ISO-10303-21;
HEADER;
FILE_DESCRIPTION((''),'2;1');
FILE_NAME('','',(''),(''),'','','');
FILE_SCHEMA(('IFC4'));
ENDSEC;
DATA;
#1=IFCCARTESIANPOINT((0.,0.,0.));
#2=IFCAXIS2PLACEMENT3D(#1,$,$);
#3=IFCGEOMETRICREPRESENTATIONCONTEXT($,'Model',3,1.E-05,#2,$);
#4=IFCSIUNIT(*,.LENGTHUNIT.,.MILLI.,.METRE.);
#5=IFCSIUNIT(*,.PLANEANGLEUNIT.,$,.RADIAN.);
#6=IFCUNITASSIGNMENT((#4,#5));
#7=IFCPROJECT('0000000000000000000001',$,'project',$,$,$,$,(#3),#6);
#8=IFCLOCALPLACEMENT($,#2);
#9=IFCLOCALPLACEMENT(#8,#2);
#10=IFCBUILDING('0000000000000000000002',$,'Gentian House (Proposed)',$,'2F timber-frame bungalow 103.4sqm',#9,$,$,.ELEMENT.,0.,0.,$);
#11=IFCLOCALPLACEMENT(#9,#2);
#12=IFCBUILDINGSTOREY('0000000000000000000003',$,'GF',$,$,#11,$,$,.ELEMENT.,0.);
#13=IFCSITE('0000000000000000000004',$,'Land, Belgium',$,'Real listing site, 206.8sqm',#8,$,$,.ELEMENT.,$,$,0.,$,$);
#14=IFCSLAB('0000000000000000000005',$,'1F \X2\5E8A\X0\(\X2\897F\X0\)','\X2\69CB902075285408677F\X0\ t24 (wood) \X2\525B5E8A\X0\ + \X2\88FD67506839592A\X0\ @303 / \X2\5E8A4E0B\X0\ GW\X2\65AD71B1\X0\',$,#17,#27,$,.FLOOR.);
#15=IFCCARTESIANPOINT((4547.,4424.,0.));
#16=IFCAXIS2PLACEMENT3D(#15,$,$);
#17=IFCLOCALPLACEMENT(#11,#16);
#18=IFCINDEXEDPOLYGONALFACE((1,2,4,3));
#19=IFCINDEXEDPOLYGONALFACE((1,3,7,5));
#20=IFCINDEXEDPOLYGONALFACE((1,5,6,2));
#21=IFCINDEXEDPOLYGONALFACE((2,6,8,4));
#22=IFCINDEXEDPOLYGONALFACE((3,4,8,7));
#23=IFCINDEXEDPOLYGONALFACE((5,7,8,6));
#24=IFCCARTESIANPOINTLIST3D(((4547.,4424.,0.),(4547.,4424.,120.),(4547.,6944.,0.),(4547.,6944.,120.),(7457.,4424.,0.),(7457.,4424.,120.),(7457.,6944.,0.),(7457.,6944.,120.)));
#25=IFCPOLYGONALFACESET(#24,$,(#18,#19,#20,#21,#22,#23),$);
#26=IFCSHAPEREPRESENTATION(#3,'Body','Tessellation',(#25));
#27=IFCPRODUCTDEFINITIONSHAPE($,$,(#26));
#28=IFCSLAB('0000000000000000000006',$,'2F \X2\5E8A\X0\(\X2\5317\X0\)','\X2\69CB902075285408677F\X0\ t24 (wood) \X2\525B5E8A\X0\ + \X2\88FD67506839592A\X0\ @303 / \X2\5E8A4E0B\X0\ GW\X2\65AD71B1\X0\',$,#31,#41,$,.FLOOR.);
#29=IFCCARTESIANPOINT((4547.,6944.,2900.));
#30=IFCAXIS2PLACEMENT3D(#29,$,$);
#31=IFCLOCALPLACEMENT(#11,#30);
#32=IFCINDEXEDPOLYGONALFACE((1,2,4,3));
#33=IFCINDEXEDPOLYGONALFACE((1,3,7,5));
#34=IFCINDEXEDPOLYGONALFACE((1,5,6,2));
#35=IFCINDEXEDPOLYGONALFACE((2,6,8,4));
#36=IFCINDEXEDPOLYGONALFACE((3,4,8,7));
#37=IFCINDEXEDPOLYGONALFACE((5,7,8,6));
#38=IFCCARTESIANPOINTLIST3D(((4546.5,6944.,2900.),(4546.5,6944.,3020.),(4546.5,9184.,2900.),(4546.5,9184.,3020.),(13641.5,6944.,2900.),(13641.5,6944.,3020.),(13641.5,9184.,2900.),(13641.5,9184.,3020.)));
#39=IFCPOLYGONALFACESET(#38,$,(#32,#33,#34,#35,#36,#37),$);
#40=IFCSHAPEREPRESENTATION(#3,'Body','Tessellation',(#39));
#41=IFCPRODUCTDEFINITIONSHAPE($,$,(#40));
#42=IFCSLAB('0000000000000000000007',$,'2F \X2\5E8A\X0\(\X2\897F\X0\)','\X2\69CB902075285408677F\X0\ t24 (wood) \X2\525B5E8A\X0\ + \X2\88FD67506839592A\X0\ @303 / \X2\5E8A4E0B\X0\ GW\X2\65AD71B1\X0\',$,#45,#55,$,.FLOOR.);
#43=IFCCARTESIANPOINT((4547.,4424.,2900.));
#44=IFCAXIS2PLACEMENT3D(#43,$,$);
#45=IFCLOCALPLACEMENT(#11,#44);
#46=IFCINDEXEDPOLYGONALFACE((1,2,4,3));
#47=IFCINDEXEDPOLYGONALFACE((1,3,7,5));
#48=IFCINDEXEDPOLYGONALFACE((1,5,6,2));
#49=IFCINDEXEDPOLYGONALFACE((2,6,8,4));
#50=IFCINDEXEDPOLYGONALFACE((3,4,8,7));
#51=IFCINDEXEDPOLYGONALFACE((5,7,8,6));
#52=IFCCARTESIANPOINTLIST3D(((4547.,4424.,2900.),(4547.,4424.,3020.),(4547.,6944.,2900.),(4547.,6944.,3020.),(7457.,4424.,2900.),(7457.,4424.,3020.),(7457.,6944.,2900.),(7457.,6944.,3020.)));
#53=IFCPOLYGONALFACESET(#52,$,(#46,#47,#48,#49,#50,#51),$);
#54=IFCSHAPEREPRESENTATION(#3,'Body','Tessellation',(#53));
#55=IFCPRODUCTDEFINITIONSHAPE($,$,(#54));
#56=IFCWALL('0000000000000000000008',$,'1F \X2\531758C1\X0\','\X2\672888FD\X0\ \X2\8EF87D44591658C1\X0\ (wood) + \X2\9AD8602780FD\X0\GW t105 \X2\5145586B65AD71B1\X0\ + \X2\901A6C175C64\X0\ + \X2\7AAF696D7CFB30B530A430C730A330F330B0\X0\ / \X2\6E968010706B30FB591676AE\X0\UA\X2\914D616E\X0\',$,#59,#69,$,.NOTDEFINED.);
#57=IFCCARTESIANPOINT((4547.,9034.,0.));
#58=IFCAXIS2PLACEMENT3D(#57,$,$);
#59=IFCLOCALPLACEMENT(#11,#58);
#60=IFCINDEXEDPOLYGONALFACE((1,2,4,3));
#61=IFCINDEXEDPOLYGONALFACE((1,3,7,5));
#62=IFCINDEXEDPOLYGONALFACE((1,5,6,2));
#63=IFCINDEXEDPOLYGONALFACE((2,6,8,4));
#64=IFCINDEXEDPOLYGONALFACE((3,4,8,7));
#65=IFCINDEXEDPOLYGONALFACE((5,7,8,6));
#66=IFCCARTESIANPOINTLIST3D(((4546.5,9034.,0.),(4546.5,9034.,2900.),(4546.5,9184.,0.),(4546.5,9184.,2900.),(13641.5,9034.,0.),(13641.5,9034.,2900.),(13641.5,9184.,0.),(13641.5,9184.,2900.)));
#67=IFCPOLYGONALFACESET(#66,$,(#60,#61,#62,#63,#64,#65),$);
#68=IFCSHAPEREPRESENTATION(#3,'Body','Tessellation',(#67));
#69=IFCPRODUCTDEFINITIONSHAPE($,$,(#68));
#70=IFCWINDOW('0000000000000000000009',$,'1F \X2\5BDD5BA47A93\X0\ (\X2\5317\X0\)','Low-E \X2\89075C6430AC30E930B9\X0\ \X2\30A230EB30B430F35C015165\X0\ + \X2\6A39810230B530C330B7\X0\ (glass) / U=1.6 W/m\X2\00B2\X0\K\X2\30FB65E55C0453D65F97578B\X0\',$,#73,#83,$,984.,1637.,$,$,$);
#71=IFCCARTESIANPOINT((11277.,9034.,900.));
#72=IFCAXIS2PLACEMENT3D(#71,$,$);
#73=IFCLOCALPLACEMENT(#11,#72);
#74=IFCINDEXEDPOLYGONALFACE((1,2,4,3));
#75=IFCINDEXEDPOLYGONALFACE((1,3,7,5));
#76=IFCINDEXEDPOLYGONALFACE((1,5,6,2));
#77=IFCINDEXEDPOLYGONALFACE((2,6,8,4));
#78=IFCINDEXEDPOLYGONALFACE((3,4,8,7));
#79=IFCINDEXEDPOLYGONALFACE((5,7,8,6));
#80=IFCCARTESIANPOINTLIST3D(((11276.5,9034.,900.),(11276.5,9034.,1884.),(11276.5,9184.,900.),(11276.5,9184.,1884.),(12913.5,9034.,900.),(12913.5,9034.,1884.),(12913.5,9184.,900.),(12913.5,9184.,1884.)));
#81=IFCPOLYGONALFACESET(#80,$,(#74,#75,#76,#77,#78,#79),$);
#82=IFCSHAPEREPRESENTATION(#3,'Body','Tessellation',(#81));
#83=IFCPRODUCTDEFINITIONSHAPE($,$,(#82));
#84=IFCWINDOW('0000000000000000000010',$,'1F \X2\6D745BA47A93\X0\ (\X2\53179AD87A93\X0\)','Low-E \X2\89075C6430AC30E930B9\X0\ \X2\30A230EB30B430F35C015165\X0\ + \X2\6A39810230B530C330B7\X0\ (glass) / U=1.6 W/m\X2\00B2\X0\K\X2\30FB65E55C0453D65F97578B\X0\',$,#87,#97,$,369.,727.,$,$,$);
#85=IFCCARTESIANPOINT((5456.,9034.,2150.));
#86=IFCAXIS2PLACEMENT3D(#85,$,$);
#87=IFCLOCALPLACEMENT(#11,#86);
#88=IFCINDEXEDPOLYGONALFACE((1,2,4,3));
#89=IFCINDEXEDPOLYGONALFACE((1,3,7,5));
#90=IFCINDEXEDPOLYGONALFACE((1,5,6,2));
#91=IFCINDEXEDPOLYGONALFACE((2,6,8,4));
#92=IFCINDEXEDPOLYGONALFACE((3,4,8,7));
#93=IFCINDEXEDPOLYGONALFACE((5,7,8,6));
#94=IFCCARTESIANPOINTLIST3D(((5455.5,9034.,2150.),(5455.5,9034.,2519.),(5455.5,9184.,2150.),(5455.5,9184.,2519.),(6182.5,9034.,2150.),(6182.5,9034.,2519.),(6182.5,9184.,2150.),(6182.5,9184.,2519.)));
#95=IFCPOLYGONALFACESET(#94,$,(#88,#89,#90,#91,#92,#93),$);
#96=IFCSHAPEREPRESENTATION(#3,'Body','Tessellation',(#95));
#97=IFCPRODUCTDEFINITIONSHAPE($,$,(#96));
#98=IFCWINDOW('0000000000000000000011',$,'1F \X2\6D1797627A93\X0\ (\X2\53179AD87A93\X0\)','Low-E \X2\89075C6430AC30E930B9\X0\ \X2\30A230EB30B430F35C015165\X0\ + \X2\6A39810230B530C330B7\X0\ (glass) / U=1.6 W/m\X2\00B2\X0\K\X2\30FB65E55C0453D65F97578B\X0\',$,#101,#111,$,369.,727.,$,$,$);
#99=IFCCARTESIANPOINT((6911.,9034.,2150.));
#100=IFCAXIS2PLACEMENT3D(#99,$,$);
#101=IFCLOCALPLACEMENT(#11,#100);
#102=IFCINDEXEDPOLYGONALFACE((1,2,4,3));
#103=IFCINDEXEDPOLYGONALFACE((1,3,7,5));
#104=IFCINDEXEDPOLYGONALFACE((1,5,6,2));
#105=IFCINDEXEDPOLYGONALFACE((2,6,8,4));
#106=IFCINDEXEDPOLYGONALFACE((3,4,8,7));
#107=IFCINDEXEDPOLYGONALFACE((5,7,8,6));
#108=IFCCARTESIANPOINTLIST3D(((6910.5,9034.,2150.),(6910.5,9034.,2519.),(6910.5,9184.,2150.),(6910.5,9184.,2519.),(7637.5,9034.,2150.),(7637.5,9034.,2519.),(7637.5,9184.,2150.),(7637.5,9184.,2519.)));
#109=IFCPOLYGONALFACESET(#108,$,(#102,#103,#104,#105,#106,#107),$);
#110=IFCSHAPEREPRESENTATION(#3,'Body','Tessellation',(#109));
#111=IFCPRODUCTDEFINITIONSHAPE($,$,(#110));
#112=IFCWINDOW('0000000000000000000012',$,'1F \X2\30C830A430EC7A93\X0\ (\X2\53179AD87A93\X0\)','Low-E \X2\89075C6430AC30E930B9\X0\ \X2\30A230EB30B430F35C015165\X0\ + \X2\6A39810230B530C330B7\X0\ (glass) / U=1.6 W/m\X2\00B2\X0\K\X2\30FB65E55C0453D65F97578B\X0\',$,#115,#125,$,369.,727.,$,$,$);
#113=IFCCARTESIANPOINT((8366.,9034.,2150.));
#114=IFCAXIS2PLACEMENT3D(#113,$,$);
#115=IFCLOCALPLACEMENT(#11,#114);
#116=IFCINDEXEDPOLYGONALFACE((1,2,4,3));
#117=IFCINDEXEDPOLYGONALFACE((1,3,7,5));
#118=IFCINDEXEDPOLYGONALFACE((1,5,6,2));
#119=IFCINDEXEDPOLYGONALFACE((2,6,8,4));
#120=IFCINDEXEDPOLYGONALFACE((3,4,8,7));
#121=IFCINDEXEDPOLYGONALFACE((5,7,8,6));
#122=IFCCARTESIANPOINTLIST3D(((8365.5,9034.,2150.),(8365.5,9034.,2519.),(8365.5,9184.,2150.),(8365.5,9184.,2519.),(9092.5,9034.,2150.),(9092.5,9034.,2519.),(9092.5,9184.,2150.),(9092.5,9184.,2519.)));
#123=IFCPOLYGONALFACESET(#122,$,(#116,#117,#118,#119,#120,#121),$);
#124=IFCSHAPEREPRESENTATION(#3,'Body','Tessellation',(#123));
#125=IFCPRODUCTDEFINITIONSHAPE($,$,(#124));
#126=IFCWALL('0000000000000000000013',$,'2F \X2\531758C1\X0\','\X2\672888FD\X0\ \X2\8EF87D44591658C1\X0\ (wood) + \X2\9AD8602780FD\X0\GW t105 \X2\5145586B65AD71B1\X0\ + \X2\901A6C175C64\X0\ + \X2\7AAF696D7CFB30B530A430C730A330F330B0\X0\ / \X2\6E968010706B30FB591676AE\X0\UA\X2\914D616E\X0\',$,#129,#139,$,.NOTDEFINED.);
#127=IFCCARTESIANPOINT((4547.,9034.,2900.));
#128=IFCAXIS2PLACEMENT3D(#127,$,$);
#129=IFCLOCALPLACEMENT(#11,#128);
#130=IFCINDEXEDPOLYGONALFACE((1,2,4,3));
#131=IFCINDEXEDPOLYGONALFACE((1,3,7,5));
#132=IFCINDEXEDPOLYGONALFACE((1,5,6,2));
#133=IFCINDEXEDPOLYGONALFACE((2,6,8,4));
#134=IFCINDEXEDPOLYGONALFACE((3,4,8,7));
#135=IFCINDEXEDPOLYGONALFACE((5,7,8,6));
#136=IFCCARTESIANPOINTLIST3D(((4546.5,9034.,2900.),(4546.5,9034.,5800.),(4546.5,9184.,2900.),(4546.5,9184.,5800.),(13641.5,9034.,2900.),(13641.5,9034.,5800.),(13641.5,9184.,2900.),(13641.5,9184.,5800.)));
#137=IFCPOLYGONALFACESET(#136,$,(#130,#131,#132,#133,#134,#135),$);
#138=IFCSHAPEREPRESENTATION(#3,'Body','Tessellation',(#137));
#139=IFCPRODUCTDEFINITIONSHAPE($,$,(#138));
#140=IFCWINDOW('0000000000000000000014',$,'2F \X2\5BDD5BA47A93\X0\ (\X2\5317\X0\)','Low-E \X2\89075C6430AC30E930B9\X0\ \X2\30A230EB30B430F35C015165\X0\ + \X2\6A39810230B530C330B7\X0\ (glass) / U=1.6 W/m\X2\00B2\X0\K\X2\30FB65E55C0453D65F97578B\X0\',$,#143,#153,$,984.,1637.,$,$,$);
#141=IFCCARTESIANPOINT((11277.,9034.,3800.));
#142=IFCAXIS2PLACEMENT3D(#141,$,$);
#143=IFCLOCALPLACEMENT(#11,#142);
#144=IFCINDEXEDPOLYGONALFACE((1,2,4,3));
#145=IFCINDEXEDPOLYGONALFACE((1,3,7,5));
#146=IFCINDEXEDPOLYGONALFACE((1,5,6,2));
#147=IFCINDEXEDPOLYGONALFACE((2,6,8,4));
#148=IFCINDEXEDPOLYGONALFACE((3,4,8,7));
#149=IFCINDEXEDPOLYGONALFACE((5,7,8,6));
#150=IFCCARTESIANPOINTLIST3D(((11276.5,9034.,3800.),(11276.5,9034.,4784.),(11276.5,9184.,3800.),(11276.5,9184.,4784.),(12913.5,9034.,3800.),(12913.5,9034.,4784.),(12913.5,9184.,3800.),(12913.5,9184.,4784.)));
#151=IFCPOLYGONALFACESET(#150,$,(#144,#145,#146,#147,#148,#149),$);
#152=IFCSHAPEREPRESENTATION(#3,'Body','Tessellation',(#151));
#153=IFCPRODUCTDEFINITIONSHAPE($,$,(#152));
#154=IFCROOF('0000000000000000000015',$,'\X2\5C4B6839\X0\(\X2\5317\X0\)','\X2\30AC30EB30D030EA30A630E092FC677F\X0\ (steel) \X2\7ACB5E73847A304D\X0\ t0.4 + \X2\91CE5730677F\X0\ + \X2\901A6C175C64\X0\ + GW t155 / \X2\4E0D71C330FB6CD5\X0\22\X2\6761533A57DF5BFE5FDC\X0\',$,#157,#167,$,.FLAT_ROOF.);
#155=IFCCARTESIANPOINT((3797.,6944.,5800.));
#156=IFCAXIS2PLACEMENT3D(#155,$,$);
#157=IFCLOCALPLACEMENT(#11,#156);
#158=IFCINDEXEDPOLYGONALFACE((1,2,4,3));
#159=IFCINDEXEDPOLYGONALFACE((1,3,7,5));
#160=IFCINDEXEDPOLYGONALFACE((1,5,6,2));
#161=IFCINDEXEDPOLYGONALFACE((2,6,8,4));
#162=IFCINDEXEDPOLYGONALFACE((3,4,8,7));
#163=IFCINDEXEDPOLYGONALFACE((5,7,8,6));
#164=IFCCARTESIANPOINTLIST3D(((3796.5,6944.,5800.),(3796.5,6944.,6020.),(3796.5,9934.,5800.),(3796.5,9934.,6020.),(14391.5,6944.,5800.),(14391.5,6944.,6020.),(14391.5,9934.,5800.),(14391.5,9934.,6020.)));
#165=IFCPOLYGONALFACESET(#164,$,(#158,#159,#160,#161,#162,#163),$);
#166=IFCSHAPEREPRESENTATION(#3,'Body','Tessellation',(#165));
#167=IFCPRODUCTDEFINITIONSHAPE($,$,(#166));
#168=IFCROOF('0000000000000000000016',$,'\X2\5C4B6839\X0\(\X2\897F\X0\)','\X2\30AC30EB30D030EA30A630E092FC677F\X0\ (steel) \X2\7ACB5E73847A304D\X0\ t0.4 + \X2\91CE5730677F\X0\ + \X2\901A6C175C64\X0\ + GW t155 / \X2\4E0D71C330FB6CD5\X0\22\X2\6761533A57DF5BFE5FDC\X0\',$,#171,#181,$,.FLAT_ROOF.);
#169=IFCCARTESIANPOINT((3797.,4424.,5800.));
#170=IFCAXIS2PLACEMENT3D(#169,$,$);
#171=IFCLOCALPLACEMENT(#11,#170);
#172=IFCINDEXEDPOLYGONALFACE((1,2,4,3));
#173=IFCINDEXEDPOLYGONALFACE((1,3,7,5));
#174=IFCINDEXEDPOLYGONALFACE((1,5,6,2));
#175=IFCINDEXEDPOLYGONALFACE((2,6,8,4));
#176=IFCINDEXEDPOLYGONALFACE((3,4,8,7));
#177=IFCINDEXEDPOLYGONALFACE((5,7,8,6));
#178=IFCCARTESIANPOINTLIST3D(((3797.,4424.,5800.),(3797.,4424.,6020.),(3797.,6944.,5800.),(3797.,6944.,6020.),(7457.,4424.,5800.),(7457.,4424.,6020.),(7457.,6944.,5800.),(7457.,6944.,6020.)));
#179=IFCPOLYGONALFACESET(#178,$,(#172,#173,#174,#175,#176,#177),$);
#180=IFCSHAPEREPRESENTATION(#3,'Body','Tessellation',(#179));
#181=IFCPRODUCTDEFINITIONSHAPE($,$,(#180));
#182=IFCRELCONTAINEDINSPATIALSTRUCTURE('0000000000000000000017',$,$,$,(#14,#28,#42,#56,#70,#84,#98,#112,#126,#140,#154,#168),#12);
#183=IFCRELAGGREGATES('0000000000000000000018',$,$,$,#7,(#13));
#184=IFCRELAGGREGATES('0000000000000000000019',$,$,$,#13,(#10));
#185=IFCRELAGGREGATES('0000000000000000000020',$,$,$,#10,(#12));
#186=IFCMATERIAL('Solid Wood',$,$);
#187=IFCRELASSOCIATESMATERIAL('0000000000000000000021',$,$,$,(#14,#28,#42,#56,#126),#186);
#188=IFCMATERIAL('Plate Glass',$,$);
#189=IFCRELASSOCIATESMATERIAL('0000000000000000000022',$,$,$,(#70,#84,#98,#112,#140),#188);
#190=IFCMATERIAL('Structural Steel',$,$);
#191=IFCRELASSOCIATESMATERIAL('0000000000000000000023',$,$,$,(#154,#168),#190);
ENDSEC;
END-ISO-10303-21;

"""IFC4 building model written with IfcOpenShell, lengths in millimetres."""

from ifc_helpers import new_model, si_unit, frame, frame_2d, origin, place, context, project, spatial, rectangle, extrude, material, element, fill, save


model = new_model("IFC4")

# Units and contexts
model_context = context("Model", 3, precision=1e-05, world=origin())
ifc_project = project(units=[si_unit("LENGTHUNIT", "METRE", prefix="MILLI"), si_unit("PLANEANGLEUNIT", "RADIAN")], contexts=[model_context])

# Site, building, storey
site_placement = place(None, origin())
site = spatial("IfcSite", under=ifc_project, at=site_placement, Name="Land, Belgium", ObjectType="Real listing site, 206.8sqm", CompositionType="ELEMENT", RefElevation=0.0)
building_placement = place(site_placement, origin())
building = spatial("IfcBuilding", under=site, at=building_placement, Name="Gentian House (Proposed)", ObjectType="2F timber-frame bungalow 103.4sqm", CompositionType="ELEMENT", ElevationOfRefHeight=0.0, ElevationOfTerrain=0.0)
storey_placement = place(building_placement, origin())
storey = spatial("IfcBuildingStorey", under=building, at=storey_placement, Name="GF", CompositionType="ELEMENT", Elevation=0.0)

# Slabs
ifc_material_1 = material(Name="Solid Wood")
slab_1_placement = place(storey_placement, frame((4547.0, 4424.0, 0.0)))
element("IfcSlab", 1, at=slab_1_placement, inside=storey, material=ifc_material_1, Name="1F 床(西)", Description="構造用合板 t24 (wood) 剛床 + 製材根太 @303 / 床下 GW断熱", PredefinedType="FLOOR", context=model_context, shape_type="SweptSolid", body=[
    extrude(rectangle(XDim=2910.0, YDim=2520.0, at=frame_2d((1455.0, 1260.0))), frame((4547.0, 4424.0, 0.0)), (0.0, 0.0, 1.0), 120.0),
])
slab_2_placement = place(storey_placement, frame((4547.0, 6944.0, 2900.0)))
element("IfcSlab", 2, at=slab_2_placement, inside=storey, material=ifc_material_1, Name="2F 床(北)", Description="構造用合板 t24 (wood) 剛床 + 製材根太 @303 / 床下 GW断熱", PredefinedType="FLOOR", context=model_context, shape_type="SweptSolid", body=[
    extrude(rectangle(XDim=9095.0, YDim=2240.0, at=frame_2d((4547.0, 1120.0))), frame((4547.0, 6944.0, 2900.0)), (0.0, 0.0, 1.0), 120.0),
])
slab_3_placement = place(storey_placement, frame((4547.0, 4424.0, 2900.0)))
element("IfcSlab", 3, at=slab_3_placement, inside=storey, material=ifc_material_1, Name="2F 床(西)", Description="構造用合板 t24 (wood) 剛床 + 製材根太 @303 / 床下 GW断熱", PredefinedType="FLOOR", context=model_context, shape_type="SweptSolid", body=[
    extrude(rectangle(XDim=2910.0, YDim=2520.0, at=frame_2d((1455.0, 1260.0))), frame((4547.0, 4424.0, 2900.0)), (0.0, 0.0, 1.0), 120.0),
])

# Wall, openings, windows
wall_1_placement = place(storey_placement, frame((4547.0, 9034.0, 0.0)))
wall_1 = element("IfcWall", 4, at=wall_1_placement, inside=storey, material=ifc_material_1, Name="1F 北壁", Description="木製 軸組外壁 (wood) + 高性能GW t105 充填断熱 + 通気層 + 窯業系サイディング / 準耐火・外皮UA配慮", PredefinedType="NOTDEFINED", context=model_context, shape_type="SweptSolid", body=[
    extrude(rectangle(XDim=9095.0, YDim=150.0, at=frame_2d((4547.0, 75.0))), frame((4547.0, 9034.0, 0.0)), (0.0, 0.0, 1.0), 2900.0),
])
opening_1_placement = place(storey_placement, frame((11277.0, 9034.0, 900.0)))
opening_1 = element("IfcOpeningElement", 5, at=opening_1_placement, cuts=wall_1, PredefinedType="NOTDEFINED", context=model_context, shape_type="SweptSolid", body=[
    extrude(rectangle(XDim=1637.0, YDim=150.0, at=frame_2d((818.0, 75.0))), frame((11277.0, 9034.0, 900.0)), (0.0, 0.0, 1.0), 984.0),
])
opening_2_placement = place(storey_placement, frame((5456.0, 9034.0, 2150.0)))
opening_2 = element("IfcOpeningElement", 6, at=opening_2_placement, cuts=wall_1, PredefinedType="NOTDEFINED", context=model_context, shape_type="SweptSolid", body=[
    extrude(rectangle(XDim=727.0, YDim=150.0, at=frame_2d((363.0, 75.0))), frame((5456.0, 9034.0, 2150.0)), (0.0, 0.0, 1.0), 369.0),
])
opening_3_placement = place(storey_placement, frame((6911.0, 9034.0, 2150.0)))
opening_3 = element("IfcOpeningElement", 7, at=opening_3_placement, cuts=wall_1, PredefinedType="NOTDEFINED", context=model_context, shape_type="SweptSolid", body=[
    extrude(rectangle(XDim=727.0, YDim=150.0, at=frame_2d((363.0, 75.0))), frame((6911.0, 9034.0, 2150.0)), (0.0, 0.0, 1.0), 369.0),
])
opening_4_placement = place(storey_placement, frame((8366.0, 9034.0, 2150.0)))
opening_4 = element("IfcOpeningElement", 8, at=opening_4_placement, cuts=wall_1, PredefinedType="NOTDEFINED", context=model_context, shape_type="SweptSolid", body=[
    extrude(rectangle(XDim=727.0, YDim=150.0, at=frame_2d((363.0, 75.0))), frame((8366.0, 9034.0, 2150.0)), (0.0, 0.0, 1.0), 369.0),
])
ifc_material_2 = material(Name="Plate Glass")
window_1_placement = place(storey_placement, frame((11277.0, 9034.0, 900.0)))
window_1 = element("IfcWindow", 9, at=window_1_placement, inside=storey, material=ifc_material_2, Name="1F 寝室窓 (北)", Description="Low-E 複層ガラス アルゴン封入 + 樹脂サッシ (glass) / U=1.6 W/m²K・日射取得型", OverallHeight=984.0, OverallWidth=1637.0, context=model_context, shape_type="SweptSolid", body=[
    extrude(rectangle(XDim=1637.0, YDim=150.0, at=frame_2d((818.0, 75.0))), frame((11277.0, 9034.0, 900.0)), (0.0, 0.0, 1.0), 984.0),
])
fill(opening_1, window_1)
window_2_placement = place(storey_placement, frame((5456.0, 9034.0, 2150.0)))
window_2 = element("IfcWindow", 10, at=window_2_placement, inside=storey, material=ifc_material_2, Name="1F 浴室窓 (北高窓)", Description="Low-E 複層ガラス アルゴン封入 + 樹脂サッシ (glass) / U=1.6 W/m²K・日射取得型", OverallHeight=369.0, OverallWidth=727.0, context=model_context, shape_type="SweptSolid", body=[
    extrude(rectangle(XDim=727.0, YDim=150.0, at=frame_2d((363.0, 75.0))), frame((5456.0, 9034.0, 2150.0)), (0.0, 0.0, 1.0), 369.0),
])
fill(opening_2, window_2)
window_3_placement = place(storey_placement, frame((6911.0, 9034.0, 2150.0)))
window_3 = element("IfcWindow", 11, at=window_3_placement, inside=storey, material=ifc_material_2, Name="1F 洗面窓 (北高窓)", Description="Low-E 複層ガラス アルゴン封入 + 樹脂サッシ (glass) / U=1.6 W/m²K・日射取得型", OverallHeight=369.0, OverallWidth=727.0, context=model_context, shape_type="SweptSolid", body=[
    extrude(rectangle(XDim=727.0, YDim=150.0, at=frame_2d((363.0, 75.0))), frame((6911.0, 9034.0, 2150.0)), (0.0, 0.0, 1.0), 369.0),
])
fill(opening_3, window_3)
window_4_placement = place(storey_placement, frame((8366.0, 9034.0, 2150.0)))
window_4 = element("IfcWindow", 12, at=window_4_placement, inside=storey, material=ifc_material_2, Name="1F トイレ窓 (北高窓)", Description="Low-E 複層ガラス アルゴン封入 + 樹脂サッシ (glass) / U=1.6 W/m²K・日射取得型", OverallHeight=369.0, OverallWidth=727.0, context=model_context, shape_type="SweptSolid", body=[
    extrude(rectangle(XDim=727.0, YDim=150.0, at=frame_2d((363.0, 75.0))), frame((8366.0, 9034.0, 2150.0)), (0.0, 0.0, 1.0), 369.0),
])
fill(opening_4, window_4)

# Wall, opening, window
wall_2_placement = place(storey_placement, frame((4547.0, 9034.0, 2900.0)))
wall_2 = element("IfcWall", 13, at=wall_2_placement, inside=storey, material=ifc_material_1, Name="2F 北壁", Description="木製 軸組外壁 (wood) + 高性能GW t105 充填断熱 + 通気層 + 窯業系サイディング / 準耐火・外皮UA配慮", PredefinedType="NOTDEFINED", context=model_context, shape_type="SweptSolid", body=[
    extrude(rectangle(XDim=9095.0, YDim=150.0, at=frame_2d((4547.0, 75.0))), frame((4547.0, 9034.0, 2900.0)), (0.0, 0.0, 1.0), 2900.0),
])
opening_5_placement = place(storey_placement, frame((11277.0, 9034.0, 3800.0)))
opening_5 = element("IfcOpeningElement", 14, at=opening_5_placement, cuts=wall_2, PredefinedType="NOTDEFINED", context=model_context, shape_type="SweptSolid", body=[
    extrude(rectangle(XDim=1637.0, YDim=150.0, at=frame_2d((818.0, 75.0))), frame((11277.0, 9034.0, 3800.0)), (0.0, 0.0, 1.0), 984.0),
])
window_5_placement = place(storey_placement, frame((11277.0, 9034.0, 3800.0)))
window_5 = element("IfcWindow", 15, at=window_5_placement, inside=storey, material=ifc_material_2, Name="2F 寝室窓 (北)", Description="Low-E 複層ガラス アルゴン封入 + 樹脂サッシ (glass) / U=1.6 W/m²K・日射取得型", OverallHeight=984.0, OverallWidth=1637.0, context=model_context, shape_type="SweptSolid", body=[
    extrude(rectangle(XDim=1637.0, YDim=150.0, at=frame_2d((818.0, 75.0))), frame((11277.0, 9034.0, 3800.0)), (0.0, 0.0, 1.0), 984.0),
])
fill(opening_5, window_5)

# Roofs
ifc_material_3 = material(Name="Structural Steel")
for number, where, name in (
    (16, (3797.0, 6944.0, 5800.0), "屋根(北)"),
):
    element("IfcRoof", number, at=place(storey_placement, frame(where)), inside=storey, material=ifc_material_3, Name=name, Description="ガルバリウム鋼板 (steel) 立平葺き t0.4 + 野地板 + 通気層 + GW t155 / 不燃・法22条区域対応", PredefinedType="FLAT_ROOF", context=model_context, shape_type="SweptSolid", body=[
        extrude(rectangle(XDim=10595.0, YDim=2990.0, at=frame_2d((5297.0, 1495.0))), frame((3797.0, 6944.0, 5800.0)), (0.0, 0.0, 1.0), 220.0),
    ])
roof_placement = place(storey_placement, frame((3797.0, 4424.0, 5800.0)))
element("IfcRoof", 17, at=roof_placement, inside=storey, material=ifc_material_3, Name="屋根(西)", Description="ガルバリウム鋼板 (steel) 立平葺き t0.4 + 野地板 + 通気層 + GW t155 / 不燃・法22条区域対応", PredefinedType="FLAT_ROOF", context=model_context, shape_type="SweptSolid", body=[
    extrude(rectangle(XDim=3660.0, YDim=2520.0, at=frame_2d((1830.0, 1260.0))), frame((3797.0, 4424.0, 5800.0)), (0.0, 0.0, 1.0), 220.0),
])

save(model, "model.ifc")
